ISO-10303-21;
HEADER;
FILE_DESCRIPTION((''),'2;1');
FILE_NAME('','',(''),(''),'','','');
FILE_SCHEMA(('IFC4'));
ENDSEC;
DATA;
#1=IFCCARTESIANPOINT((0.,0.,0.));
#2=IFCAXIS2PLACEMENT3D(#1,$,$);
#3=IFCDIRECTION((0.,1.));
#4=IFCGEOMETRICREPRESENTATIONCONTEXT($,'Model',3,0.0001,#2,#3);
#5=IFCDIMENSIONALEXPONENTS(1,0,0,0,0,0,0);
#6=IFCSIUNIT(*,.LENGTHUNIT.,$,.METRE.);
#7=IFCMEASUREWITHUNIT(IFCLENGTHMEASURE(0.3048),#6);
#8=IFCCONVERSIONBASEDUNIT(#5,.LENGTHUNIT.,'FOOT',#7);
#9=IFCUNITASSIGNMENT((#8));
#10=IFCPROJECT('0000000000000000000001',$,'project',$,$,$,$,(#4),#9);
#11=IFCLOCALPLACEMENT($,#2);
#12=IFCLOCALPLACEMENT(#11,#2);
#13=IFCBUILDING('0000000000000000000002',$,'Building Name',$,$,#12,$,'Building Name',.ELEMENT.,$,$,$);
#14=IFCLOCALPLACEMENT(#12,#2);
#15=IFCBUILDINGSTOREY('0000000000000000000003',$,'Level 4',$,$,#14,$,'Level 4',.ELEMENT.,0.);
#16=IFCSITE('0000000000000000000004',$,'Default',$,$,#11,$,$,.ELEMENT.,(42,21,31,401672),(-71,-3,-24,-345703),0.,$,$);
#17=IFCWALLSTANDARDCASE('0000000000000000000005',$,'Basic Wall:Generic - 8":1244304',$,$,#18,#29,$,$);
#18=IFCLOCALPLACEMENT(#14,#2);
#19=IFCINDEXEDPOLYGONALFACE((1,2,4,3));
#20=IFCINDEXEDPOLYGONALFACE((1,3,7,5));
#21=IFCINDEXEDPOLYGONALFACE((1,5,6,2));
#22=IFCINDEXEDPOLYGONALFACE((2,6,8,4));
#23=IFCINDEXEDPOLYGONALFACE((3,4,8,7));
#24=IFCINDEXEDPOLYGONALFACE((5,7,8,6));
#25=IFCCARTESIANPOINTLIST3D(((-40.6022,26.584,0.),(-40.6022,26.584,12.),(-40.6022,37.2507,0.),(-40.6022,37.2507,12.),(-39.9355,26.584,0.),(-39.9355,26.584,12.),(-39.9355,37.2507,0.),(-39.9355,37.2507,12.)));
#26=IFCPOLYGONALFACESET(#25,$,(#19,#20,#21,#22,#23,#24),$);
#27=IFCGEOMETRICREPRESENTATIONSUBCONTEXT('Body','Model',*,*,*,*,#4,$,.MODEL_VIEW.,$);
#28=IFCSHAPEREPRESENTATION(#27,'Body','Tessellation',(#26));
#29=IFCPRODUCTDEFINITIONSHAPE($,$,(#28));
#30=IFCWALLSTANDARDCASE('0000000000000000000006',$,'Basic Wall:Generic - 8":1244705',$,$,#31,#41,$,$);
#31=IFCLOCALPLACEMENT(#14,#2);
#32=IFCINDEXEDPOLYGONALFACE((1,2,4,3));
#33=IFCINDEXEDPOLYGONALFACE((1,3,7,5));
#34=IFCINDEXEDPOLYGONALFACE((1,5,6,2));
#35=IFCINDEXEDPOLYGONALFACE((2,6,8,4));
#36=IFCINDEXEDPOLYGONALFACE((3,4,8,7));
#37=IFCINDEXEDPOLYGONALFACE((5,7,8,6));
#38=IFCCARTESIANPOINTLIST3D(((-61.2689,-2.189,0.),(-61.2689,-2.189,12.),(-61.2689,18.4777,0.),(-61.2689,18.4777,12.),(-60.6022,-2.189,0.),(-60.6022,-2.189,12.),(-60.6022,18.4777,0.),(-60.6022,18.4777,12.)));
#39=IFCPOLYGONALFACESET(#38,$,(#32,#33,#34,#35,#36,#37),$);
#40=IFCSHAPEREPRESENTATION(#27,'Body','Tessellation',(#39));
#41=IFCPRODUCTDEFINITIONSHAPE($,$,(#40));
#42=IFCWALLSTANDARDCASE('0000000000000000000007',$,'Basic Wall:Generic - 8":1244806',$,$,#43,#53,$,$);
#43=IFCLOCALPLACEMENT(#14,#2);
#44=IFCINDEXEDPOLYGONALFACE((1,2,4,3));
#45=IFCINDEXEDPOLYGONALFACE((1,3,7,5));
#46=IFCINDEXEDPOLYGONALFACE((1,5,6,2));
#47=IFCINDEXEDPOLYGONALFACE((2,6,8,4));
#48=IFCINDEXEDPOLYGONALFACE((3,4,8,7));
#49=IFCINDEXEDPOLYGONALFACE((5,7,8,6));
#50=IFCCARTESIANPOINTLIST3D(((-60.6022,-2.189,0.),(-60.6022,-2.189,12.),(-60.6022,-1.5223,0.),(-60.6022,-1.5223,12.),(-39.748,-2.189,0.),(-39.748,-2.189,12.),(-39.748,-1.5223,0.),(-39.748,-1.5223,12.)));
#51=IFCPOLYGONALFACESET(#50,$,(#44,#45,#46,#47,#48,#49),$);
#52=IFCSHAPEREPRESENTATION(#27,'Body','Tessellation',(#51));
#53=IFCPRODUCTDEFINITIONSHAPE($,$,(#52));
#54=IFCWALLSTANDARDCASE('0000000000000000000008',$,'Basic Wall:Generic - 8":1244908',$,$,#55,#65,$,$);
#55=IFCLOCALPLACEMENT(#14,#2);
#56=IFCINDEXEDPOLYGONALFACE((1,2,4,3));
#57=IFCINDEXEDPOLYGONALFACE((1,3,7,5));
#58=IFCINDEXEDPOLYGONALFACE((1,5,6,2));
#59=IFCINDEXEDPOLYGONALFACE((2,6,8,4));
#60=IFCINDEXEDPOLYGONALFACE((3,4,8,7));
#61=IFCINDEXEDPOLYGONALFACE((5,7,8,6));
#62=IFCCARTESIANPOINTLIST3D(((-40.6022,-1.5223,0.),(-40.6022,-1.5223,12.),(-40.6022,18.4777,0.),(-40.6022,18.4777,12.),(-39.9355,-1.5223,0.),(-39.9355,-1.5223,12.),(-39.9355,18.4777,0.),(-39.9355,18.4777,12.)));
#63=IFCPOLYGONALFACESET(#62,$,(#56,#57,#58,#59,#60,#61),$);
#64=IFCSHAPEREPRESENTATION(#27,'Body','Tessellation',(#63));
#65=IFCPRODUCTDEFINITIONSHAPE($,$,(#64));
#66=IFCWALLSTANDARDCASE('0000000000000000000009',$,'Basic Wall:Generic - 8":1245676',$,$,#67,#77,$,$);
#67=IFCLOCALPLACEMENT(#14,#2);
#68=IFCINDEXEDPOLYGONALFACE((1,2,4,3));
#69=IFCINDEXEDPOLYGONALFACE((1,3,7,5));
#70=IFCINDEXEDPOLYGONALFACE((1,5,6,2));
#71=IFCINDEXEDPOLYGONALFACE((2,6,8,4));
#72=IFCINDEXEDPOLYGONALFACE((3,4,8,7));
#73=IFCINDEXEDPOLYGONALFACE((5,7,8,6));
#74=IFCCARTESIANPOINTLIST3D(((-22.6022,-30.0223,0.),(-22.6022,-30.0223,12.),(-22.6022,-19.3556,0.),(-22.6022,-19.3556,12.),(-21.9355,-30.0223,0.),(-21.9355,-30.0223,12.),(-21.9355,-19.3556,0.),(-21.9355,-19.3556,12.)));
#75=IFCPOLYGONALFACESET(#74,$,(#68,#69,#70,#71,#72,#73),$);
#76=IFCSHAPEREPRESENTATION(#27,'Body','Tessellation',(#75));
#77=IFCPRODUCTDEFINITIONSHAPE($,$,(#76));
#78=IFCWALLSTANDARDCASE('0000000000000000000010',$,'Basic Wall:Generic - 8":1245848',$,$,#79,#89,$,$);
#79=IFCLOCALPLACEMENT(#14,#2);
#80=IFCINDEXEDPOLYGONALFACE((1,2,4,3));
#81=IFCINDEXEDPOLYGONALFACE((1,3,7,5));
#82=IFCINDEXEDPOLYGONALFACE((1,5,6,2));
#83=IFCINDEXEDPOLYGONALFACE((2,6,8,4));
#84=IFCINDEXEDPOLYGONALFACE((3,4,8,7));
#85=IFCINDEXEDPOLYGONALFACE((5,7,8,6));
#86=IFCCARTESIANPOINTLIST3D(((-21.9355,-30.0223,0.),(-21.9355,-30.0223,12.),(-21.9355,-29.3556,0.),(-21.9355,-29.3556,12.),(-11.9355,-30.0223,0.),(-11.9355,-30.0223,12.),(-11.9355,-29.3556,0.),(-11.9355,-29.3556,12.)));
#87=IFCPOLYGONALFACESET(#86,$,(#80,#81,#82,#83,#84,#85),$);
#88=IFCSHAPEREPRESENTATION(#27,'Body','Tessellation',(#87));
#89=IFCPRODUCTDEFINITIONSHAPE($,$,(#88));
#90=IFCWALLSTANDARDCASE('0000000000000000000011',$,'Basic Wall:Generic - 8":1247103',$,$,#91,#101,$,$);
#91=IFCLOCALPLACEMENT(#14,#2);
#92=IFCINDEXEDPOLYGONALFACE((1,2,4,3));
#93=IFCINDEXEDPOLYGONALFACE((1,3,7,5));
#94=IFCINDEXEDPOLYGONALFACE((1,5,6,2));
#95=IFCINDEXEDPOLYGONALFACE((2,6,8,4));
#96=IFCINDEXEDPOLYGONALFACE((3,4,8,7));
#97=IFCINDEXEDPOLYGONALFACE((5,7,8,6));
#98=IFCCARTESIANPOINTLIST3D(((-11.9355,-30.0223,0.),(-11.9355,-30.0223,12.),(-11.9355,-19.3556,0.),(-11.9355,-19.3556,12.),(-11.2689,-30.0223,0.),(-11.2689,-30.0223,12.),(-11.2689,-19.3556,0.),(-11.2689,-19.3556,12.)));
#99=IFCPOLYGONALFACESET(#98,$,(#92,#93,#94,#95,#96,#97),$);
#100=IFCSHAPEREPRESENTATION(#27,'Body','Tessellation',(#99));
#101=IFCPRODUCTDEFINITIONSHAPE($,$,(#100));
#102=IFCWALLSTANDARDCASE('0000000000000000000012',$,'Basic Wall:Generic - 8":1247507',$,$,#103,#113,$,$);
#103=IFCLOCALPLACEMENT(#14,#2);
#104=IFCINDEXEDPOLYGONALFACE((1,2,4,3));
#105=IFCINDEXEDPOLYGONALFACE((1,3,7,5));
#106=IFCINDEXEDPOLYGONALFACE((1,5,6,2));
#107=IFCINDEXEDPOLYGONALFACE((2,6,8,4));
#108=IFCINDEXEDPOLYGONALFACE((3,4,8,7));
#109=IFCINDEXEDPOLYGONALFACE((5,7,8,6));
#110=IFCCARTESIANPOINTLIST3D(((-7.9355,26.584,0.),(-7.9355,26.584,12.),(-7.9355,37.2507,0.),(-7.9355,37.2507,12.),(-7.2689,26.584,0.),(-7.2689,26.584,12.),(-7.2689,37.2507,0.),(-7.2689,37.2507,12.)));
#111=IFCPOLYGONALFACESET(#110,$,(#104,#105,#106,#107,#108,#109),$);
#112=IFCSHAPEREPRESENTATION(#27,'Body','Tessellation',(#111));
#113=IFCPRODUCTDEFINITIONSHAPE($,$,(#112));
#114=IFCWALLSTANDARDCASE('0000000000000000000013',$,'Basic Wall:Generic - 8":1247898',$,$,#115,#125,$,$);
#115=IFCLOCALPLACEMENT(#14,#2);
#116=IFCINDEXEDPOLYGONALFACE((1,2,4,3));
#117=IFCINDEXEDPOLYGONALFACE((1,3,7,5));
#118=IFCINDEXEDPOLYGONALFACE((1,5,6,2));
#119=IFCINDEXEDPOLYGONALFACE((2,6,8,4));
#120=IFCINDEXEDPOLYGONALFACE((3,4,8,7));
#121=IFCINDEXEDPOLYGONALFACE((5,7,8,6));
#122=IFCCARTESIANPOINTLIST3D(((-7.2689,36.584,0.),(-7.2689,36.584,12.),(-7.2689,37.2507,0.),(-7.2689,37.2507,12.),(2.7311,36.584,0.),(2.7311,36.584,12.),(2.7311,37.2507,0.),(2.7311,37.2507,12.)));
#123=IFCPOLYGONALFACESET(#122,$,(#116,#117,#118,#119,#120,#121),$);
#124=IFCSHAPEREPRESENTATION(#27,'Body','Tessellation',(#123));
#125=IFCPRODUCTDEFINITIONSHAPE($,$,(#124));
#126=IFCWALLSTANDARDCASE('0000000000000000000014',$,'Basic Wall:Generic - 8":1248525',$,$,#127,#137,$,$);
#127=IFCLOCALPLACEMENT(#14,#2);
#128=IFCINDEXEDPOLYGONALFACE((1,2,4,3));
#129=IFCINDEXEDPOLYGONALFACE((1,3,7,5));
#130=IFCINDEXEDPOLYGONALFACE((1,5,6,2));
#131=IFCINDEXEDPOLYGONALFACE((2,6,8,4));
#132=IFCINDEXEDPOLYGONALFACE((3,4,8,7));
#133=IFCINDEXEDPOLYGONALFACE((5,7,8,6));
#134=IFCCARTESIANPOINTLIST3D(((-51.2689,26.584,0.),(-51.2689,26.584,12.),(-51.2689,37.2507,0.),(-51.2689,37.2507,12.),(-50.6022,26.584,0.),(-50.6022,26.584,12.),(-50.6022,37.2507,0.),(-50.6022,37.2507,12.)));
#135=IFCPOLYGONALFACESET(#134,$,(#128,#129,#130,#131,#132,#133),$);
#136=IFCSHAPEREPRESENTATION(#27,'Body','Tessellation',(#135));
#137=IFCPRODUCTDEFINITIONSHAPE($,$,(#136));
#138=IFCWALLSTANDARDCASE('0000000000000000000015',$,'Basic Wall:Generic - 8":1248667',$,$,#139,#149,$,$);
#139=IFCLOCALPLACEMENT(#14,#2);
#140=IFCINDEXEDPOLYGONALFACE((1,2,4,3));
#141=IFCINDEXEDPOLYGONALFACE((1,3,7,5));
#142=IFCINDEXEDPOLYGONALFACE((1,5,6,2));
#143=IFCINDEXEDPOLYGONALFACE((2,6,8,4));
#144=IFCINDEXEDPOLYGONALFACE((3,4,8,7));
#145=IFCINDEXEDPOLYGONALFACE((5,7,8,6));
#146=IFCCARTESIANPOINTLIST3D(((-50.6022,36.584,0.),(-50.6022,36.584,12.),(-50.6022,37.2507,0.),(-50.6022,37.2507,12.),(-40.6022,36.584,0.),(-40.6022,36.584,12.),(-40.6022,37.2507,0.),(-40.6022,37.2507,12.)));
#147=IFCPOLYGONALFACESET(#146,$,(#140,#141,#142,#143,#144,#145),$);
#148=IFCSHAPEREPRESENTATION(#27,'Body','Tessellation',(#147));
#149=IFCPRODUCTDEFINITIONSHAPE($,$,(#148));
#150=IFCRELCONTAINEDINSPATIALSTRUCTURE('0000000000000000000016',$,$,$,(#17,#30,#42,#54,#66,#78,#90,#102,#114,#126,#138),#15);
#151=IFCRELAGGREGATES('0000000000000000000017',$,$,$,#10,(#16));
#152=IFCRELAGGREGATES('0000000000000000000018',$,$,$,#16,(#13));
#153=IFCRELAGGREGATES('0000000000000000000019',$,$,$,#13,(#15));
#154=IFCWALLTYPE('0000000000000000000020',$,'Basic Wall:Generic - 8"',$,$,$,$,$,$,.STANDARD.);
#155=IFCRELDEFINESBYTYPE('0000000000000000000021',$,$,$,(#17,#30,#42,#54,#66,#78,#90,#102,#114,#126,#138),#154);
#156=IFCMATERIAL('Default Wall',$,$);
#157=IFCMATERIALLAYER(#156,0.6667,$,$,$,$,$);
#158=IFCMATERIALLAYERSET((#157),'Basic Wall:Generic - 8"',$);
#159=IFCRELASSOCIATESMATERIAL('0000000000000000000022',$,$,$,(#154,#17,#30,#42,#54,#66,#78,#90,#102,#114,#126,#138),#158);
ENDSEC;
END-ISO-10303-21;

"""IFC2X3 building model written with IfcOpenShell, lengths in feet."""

from ifc_helpers import new_model, entity, si_unit, converted_unit, direction, frame, frame_2d, origin, place, context, subcontext, project, spatial, rectangle, extrude, material, layer, layer_set, layer_usage, type_object, element, save


model = new_model("IFC2X3")

# Units and contexts
model_context = context("Model", 3, precision=0.0001, world=origin(), true_north=direction((0.0, 1.0)))
body_context = subcontext(model_context, "Body", "Model", "MODEL_VIEW")
ifc_project = project(units=[converted_unit("LENGTHUNIT", "FOOT", entity("IfcLengthMeasure", 0.3048), si_unit("LENGTHUNIT", "METRE"), dimensions=[1, 0, 0, 0, 0, 0, 0])], contexts=[model_context])

# Site, building, storey
site_placement = place(None, origin())
site = spatial("IfcSite", under=ifc_project, at=site_placement, Name="Default", CompositionType="ELEMENT", RefLatitude=(42, 21, 31, 401672), RefLongitude=(-71, -3, -24, -345703), RefElevation=0.0)
building_placement = place(site_placement, origin())
building = spatial("IfcBuilding", under=site, at=building_placement, Name="Building Name", LongName="Building Name", CompositionType="ELEMENT")
storey_placement = place(building_placement, origin())
storey = spatial("IfcBuildingStorey", under=building, at=storey_placement, Name="Level 4", LongName="Level 4", CompositionType="ELEMENT", Elevation=0.0)

# Walls
ifc_material_1 = material(Name="Default Wall")
ifc_layer_1 = layer(ifc_material_1, 0.6667)
ifc_layer_set_1 = layer_set([ifc_layer_1], Name="Basic Wall:Generic - 8\"")
wall_type_1 = type_object("IfcWallType", Name="Basic Wall:Generic - 8\"", PredefinedType="STANDARD", material=ifc_layer_set_1)
ifc_layer_usage_1 = layer_usage(ifc_layer_set_1, "AXIS2", "NEGATIVE", 0.3333)
wall_1_placement = place(storey_placement, frame((-40.2689, 26.584, 0.0), z_axis=(0.0, 0.0, 1.0), x_axis=(0.0, 1.0, 0.0)))
element("IfcWallStandardCase", 1, at=wall_1_placement, inside=storey, type_object=wall_type_1, material=ifc_layer_usage_1, Name="Basic Wall:Generic - 8\":1244304", context=body_context, shape_type="SweptSolid", body=[
    extrude(rectangle(XDim=10.6667, YDim=0.6667, at=frame_2d((5.3333, 0.0), x_axis=(-1.0, 0.0))), origin(), (0.0, 0.0, 1.0), 12.0),
])
ifc_layer_usage_2 = layer_usage(ifc_layer_set_1, "AXIS2", "NEGATIVE", 0.3333)
wall_2_placement = place(storey_placement, frame((-60.9355, 18.4777, 0.0), z_axis=(0.0, 0.0, 1.0), x_axis=(0.0, -1.0, 0.0)))
element("IfcWallStandardCase", 2, at=wall_2_placement, inside=storey, type_object=wall_type_1, material=ifc_layer_usage_2, Name="Basic Wall:Generic - 8\":1244705", context=body_context, shape_type="SweptSolid", body=[
    extrude(rectangle(XDim=20.6667, YDim=0.6667, at=frame_2d((10.3333, 0.0), x_axis=(-1.0, 0.0))), origin(), (0.0, 0.0, 1.0), 12.0),
])
ifc_layer_usage_3 = layer_usage(ifc_layer_set_1, "AXIS2", "NEGATIVE", 0.3333)
wall_3_placement = place(storey_placement, frame((-60.6022, -1.8556, 0.0)))
element("IfcWallStandardCase", 3, at=wall_3_placement, inside=storey, type_object=wall_type_1, material=ifc_layer_usage_3, Name="Basic Wall:Generic - 8\":1244806", context=body_context, shape_type="SweptSolid", body=[
    extrude(rectangle(XDim=20.8542, YDim=0.6667, at=frame_2d((10.4271, 0.0), x_axis=(-1.0, 0.0))), origin(), (0.0, 0.0, 1.0), 12.0),
])
ifc_layer_usage_4 = layer_usage(ifc_layer_set_1, "AXIS2", "POSITIVE", -0.3333)
wall_4_placement = place(storey_placement, frame((-40.2689, 18.4777, 0.0), z_axis=(0.0, 0.0, 1.0), x_axis=(0.0, -1.0, 0.0)))
element("IfcWallStandardCase", 4, at=wall_4_placement, inside=storey, type_object=wall_type_1, material=ifc_layer_usage_4, Name="Basic Wall:Generic - 8\":1244908", context=body_context, shape_type="SweptSolid", body=[
    extrude(rectangle(XDim=20.0, YDim=0.6667, at=frame_2d((10.0, 0.0), x_axis=(-1.0, 0.0))), origin(), (0.0, 0.0, 1.0), 12.0),
])
ifc_layer_usage_5 = layer_usage(ifc_layer_set_1, "AXIS2", "POSITIVE", -0.3333)
wall_5_placement = place(storey_placement, frame((-22.2689, -19.3556, 0.0), z_axis=(0.0, 0.0, 1.0), x_axis=(0.0, -1.0, 0.0)))
element("IfcWallStandardCase", 5, at=wall_5_placement, inside=storey, type_object=wall_type_1, material=ifc_layer_usage_5, Name="Basic Wall:Generic - 8\":1245676", context=body_context, shape_type="SweptSolid", body=[
    extrude(rectangle(XDim=10.6667, YDim=0.6667, at=frame_2d((5.3333, 0.0), x_axis=(-1.0, 0.0))), origin(), (0.0, 0.0, 1.0), 12.0),
])
ifc_layer_usage_6 = layer_usage(ifc_layer_set_1, "AXIS2", "POSITIVE", -0.3333)
wall_6_placement = place(storey_placement, frame((-21.9355, -29.689, 0.0)))
element("IfcWallStandardCase", 6, at=wall_6_placement, inside=storey, type_object=wall_type_1, material=ifc_layer_usage_6, Name="Basic Wall:Generic - 8\":1245848", context=body_context, shape_type="SweptSolid", body=[
    extrude(rectangle(XDim=10.0, YDim=0.6667, at=frame_2d((5.0, 0.0), x_axis=(-1.0, 0.0))), origin(), (0.0, 0.0, 1.0), 12.0),
])
ifc_layer_usage_7 = layer_usage(ifc_layer_set_1, "AXIS2", "NEGATIVE", 0.3333)
wall_7_placement = place(storey_placement, frame((-11.6022, -19.3556, 0.0), z_axis=(0.0, 0.0, 1.0), x_axis=(0.0, -1.0, 0.0)))
element("IfcWallStandardCase", 7, at=wall_7_placement, inside=storey, type_object=wall_type_1, material=ifc_layer_usage_7, Name="Basic Wall:Generic - 8\":1247103", context=body_context, shape_type="SweptSolid", body=[
    extrude(rectangle(XDim=10.6667, YDim=0.6667, at=frame_2d((5.3333, 0.0), x_axis=(-1.0, 0.0))), origin(), (0.0, 0.0, 1.0), 12.0),
])
ifc_layer_usage_8 = layer_usage(ifc_layer_set_1, "AXIS2", "POSITIVE", -0.3333)
wall_8_placement = place(storey_placement, frame((-7.6022, 37.2507, 0.0), z_axis=(0.0, 0.0, 1.0), x_axis=(0.0, -1.0, 0.0)))
element("IfcWallStandardCase", 8, at=wall_8_placement, inside=storey, type_object=wall_type_1, material=ifc_layer_usage_8, Name="Basic Wall:Generic - 8\":1247507", context=body_context, shape_type="SweptSolid", body=[
    extrude(rectangle(XDim=10.6667, YDim=0.6667, at=frame_2d((5.3333, 0.0), x_axis=(-1.0, 0.0))), origin(), (0.0, 0.0, 1.0), 12.0),
])
ifc_layer_usage_9 = layer_usage(ifc_layer_set_1, "AXIS2", "NEGATIVE", 0.3333)
wall_9_placement = place(storey_placement, frame((-7.2689, 36.9174, 0.0)))
element("IfcWallStandardCase", 9, at=wall_9_placement, inside=storey, type_object=wall_type_1, material=ifc_layer_usage_9, Name="Basic Wall:Generic - 8\":1247898", context=body_context, shape_type="SweptSolid", body=[
    extrude(rectangle(XDim=10.0, YDim=0.6667, at=frame_2d((5.0, 0.0), x_axis=(-1.0, 0.0))), origin(), (0.0, 0.0, 1.0), 12.0),
])
ifc_layer_usage_10 = layer_usage(ifc_layer_set_1, "AXIS2", "NEGATIVE", 0.3333)
wall_10_placement = place(storey_placement, frame((-50.9355, 26.584, 0.0), z_axis=(0.0, 0.0, 1.0), x_axis=(0.0, 1.0, 0.0)))
element("IfcWallStandardCase", 10, at=wall_10_placement, inside=storey, type_object=wall_type_1, material=ifc_layer_usage_10, Name="Basic Wall:Generic - 8\":1248525", context=body_context, shape_type="SweptSolid", body=[
    extrude(rectangle(XDim=10.6667, YDim=0.6667, at=frame_2d((5.3333, 0.0), x_axis=(-1.0, 0.0))), origin(), (0.0, 0.0, 1.0), 12.0),
])
ifc_layer_usage_11 = layer_usage(ifc_layer_set_1, "AXIS2", "POSITIVE", -0.3333)
wall_11_placement = place(storey_placement, frame((-50.6022, 36.9174, 0.0)))
element("IfcWallStandardCase", 11, at=wall_11_placement, inside=storey, type_object=wall_type_1, material=ifc_layer_usage_11, Name="Basic Wall:Generic - 8\":1248667", context=body_context, shape_type="SweptSolid", body=[
    extrude(rectangle(XDim=10.0, YDim=0.6667, at=frame_2d((5.0, 0.0), x_axis=(-1.0, 0.0))), origin(), (0.0, 0.0, 1.0), 12.0),
])

save(model, "model.ifc")
